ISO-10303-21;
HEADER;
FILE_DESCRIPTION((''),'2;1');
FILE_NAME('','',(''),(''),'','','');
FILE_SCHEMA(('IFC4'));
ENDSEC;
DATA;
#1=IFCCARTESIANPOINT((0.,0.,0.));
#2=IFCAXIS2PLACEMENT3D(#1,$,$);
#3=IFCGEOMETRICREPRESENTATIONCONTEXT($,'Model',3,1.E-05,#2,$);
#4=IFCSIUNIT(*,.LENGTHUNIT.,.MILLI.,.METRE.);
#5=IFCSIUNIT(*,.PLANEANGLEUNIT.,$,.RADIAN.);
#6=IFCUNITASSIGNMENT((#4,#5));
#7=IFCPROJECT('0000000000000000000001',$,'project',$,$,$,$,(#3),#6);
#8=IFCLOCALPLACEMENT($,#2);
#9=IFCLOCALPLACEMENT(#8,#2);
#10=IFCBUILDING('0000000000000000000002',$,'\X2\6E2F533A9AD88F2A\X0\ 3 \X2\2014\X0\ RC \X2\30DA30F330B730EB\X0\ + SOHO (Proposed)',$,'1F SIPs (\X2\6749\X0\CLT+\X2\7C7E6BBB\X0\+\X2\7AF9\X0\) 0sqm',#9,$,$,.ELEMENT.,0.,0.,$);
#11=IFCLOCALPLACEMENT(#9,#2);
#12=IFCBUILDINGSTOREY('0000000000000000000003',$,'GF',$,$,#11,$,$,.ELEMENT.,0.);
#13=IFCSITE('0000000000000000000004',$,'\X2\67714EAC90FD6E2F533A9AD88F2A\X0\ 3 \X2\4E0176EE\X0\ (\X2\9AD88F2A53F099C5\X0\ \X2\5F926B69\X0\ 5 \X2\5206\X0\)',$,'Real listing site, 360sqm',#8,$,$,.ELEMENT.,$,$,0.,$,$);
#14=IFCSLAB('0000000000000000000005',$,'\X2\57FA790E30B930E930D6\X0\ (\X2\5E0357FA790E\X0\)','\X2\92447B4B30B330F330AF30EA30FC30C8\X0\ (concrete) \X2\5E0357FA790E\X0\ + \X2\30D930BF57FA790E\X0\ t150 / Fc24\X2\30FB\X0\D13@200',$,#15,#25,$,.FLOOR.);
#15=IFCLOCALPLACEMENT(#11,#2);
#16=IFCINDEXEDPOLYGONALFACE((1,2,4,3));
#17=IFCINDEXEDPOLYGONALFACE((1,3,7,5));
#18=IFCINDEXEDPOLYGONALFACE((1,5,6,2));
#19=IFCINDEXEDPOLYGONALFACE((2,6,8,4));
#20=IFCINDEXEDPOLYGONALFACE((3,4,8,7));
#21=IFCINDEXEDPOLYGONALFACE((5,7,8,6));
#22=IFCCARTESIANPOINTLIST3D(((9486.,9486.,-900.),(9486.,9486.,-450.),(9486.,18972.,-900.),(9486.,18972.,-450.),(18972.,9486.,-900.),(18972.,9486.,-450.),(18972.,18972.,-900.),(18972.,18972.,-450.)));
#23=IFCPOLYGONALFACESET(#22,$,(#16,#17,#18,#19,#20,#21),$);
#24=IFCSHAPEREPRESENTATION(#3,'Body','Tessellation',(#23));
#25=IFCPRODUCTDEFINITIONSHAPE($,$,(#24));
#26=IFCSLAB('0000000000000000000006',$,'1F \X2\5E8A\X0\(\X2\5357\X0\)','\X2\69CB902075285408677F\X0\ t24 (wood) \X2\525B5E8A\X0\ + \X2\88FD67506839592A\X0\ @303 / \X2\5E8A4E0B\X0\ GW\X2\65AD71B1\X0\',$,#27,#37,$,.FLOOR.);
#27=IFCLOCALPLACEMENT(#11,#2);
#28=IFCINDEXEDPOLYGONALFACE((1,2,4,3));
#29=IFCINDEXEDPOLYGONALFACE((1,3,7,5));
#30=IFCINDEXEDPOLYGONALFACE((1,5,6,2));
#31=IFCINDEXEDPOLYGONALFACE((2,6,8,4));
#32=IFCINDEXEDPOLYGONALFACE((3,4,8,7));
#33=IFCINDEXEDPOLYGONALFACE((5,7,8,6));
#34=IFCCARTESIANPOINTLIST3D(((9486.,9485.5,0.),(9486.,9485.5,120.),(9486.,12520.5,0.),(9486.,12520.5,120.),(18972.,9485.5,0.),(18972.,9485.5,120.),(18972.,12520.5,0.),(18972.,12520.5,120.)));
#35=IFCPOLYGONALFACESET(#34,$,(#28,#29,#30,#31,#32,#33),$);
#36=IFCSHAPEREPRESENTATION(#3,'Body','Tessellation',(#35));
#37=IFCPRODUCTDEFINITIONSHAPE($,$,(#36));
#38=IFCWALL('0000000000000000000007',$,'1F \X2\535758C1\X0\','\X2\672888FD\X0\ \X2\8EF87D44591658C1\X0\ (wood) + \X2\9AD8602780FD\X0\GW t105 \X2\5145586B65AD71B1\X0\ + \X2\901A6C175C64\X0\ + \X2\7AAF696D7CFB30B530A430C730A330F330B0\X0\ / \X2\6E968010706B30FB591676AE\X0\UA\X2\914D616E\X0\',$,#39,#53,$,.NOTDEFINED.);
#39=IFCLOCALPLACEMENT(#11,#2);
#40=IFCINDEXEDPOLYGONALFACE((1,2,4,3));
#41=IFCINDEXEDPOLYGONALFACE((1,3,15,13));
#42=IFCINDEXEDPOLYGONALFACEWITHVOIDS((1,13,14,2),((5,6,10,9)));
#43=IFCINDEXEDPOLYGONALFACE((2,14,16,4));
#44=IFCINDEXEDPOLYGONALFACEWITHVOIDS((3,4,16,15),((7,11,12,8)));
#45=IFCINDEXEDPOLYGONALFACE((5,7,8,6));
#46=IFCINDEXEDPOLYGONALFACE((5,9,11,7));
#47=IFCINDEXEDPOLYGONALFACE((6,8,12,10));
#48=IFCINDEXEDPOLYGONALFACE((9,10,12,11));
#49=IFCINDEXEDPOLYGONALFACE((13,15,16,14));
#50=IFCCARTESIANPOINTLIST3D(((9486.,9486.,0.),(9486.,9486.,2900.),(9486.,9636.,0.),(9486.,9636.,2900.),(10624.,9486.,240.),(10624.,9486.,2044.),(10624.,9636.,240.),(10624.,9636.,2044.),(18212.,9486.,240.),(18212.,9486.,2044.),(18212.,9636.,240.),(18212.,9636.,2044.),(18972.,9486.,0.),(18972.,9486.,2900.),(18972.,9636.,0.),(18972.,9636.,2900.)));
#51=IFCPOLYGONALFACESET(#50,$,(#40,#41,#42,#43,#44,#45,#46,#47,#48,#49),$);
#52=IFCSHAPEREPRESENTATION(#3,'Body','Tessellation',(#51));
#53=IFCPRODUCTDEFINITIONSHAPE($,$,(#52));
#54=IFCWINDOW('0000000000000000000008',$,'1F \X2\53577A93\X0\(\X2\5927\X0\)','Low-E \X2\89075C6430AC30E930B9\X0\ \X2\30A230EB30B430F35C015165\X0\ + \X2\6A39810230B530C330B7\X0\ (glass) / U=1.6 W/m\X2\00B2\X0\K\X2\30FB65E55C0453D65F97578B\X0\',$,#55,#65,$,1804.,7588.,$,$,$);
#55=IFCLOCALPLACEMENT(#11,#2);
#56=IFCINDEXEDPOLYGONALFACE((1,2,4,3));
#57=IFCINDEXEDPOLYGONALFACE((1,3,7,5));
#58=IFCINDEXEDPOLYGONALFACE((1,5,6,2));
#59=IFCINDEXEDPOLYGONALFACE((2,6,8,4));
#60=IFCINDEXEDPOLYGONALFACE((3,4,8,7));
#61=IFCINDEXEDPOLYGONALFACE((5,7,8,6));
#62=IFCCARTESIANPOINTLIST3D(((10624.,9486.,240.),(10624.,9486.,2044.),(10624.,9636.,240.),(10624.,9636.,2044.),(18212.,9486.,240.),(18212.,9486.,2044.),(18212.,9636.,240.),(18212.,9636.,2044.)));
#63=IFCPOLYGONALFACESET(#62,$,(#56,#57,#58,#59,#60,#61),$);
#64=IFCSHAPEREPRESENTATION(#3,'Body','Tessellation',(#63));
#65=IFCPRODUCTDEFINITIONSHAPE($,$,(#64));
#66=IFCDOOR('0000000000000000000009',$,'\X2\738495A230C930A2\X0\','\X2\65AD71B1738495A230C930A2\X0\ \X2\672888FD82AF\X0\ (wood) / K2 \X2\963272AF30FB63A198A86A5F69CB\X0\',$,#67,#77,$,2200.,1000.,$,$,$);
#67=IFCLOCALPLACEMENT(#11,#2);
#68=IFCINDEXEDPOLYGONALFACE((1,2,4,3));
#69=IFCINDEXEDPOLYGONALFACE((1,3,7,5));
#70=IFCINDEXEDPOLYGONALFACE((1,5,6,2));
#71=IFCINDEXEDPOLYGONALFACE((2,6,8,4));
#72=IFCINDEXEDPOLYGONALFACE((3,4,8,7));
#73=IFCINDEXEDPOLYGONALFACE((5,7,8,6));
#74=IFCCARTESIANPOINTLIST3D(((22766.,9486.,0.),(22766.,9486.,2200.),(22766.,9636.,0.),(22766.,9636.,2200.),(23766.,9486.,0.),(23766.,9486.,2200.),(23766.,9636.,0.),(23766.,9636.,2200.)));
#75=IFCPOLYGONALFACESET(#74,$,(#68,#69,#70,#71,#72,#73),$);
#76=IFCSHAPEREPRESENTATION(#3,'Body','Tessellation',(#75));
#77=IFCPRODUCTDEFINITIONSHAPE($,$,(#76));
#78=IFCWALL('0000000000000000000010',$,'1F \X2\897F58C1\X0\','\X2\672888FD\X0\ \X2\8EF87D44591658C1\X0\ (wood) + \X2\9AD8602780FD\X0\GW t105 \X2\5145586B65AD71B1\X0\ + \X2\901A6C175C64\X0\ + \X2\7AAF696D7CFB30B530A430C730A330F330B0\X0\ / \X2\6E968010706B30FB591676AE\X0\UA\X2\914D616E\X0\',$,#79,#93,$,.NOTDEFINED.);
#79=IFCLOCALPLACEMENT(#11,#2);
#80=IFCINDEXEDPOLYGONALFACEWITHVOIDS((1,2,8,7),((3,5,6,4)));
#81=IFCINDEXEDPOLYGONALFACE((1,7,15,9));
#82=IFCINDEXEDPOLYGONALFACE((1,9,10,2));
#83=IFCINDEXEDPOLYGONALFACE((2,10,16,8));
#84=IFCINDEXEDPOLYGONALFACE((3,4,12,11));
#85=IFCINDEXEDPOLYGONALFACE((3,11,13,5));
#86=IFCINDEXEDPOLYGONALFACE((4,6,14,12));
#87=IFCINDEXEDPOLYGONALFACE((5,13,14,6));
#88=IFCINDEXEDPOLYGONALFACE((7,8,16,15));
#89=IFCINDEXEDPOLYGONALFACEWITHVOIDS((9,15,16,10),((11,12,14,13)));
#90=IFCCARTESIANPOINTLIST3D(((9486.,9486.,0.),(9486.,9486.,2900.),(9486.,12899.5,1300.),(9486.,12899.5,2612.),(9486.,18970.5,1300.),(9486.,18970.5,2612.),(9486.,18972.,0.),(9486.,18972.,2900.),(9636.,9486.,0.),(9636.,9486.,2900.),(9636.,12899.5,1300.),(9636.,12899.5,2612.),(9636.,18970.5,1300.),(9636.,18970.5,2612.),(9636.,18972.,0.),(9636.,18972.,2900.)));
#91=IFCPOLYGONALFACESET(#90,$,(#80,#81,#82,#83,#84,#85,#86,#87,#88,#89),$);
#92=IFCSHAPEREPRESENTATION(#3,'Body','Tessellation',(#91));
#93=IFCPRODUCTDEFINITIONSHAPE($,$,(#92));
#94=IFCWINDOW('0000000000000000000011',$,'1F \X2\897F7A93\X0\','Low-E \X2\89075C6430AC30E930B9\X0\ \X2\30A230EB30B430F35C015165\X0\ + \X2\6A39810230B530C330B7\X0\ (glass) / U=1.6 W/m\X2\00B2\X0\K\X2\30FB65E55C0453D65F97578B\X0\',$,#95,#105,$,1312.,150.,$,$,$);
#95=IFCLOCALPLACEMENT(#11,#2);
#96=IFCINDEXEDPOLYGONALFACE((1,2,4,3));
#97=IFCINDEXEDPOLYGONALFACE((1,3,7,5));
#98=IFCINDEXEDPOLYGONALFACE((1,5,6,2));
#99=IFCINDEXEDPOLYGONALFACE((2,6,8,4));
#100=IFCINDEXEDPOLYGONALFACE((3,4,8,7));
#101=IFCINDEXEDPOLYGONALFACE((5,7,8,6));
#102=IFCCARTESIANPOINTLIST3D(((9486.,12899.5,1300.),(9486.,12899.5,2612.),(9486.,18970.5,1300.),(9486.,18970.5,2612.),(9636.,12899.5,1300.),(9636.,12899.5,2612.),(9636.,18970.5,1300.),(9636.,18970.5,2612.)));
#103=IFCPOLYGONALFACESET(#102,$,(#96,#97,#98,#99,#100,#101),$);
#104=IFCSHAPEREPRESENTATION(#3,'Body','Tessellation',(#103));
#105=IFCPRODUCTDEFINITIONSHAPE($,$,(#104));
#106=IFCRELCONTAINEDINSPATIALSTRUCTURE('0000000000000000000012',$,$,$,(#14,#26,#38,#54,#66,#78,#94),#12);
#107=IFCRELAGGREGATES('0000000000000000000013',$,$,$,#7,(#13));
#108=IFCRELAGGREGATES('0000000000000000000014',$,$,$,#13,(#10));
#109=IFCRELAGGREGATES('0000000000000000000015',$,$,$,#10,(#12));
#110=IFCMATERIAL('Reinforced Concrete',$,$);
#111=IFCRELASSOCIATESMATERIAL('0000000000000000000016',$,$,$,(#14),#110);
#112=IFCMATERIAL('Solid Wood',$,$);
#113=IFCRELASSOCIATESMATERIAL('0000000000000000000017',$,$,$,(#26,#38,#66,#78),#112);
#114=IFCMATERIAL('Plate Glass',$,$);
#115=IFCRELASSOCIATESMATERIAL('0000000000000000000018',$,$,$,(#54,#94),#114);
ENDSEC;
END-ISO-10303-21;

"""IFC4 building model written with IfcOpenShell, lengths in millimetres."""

from ifc_helpers import new_model, si_unit, frame, frame_2d, origin, place, context, project, spatial, rectangle, extrude, material, element, fill, save


model = new_model("IFC4")

# Units and contexts
model_context = context("Model", 3, precision=1e-05, world=origin())
ifc_project = project(units=[si_unit("LENGTHUNIT", "METRE", prefix="MILLI"), si_unit("PLANEANGLEUNIT", "RADIAN")], contexts=[model_context])

# Site, building, storey
site_placement = place(None, origin())
site = spatial("IfcSite", under=ifc_project, at=site_placement, Name="東京都港区高輪 3 丁目 (高輪台駅 徒歩 5 分)", ObjectType="Real listing site, 360sqm", CompositionType="ELEMENT", RefElevation=0.0)
building_placement = place(site_placement, origin())
building = spatial("IfcBuilding", under=site, at=building_placement, Name="港区高輪 3 — RC ペンシル + SOHO (Proposed)", ObjectType="1F SIPs (杉CLT+籾殻+竹) 0sqm", CompositionType="ELEMENT", ElevationOfRefHeight=0.0, ElevationOfTerrain=0.0)
storey_placement = place(building_placement, origin())
storey = spatial("IfcBuildingStorey", under=building, at=storey_placement, Name="GF", CompositionType="ELEMENT", Elevation=0.0)

# Slabs
ifc_material_1 = material(Name="Reinforced Concrete")
slab_1_placement = place(storey_placement, frame((4743.0, 4743.0, -450.0)))
element("IfcSlab", 1, at=slab_1_placement, inside=storey, material=ifc_material_1, Name="基礎スラブ (布基礎)", Description="鉄筋コンクリート (concrete) 布基礎 + ベタ基礎 t150 / Fc24・D13@200", PredefinedType="FLOOR", context=model_context, shape_type="SweptSolid", body=[
    extrude(rectangle(XDim=9486.0, YDim=9486.0, at=frame_2d((4743.0, 4743.0))), frame((4743.0, 4743.0, -450.0)), (0.0, 0.0, 1.0), 450.0),
])
ifc_material_2 = material(Name="Solid Wood")
slab_2_placement = place(storey_placement, frame((4743.0, 4743.0, 0.0)))
element("IfcSlab", 2, at=slab_2_placement, inside=storey, material=ifc_material_2, Name="1F 床(南)", Description="構造用合板 t24 (wood) 剛床 + 製材根太 @303 / 床下 GW断熱", PredefinedType="FLOOR", context=model_context, shape_type="SweptSolid", body=[
    extrude(rectangle(XDim=9486.0, YDim=3035.0, at=frame_2d((4743.0, 1517.0))), frame((4743.0, 4743.0, 0.0)), (0.0, 0.0, 1.0), 120.0),
])

# Wall, openings, window, door
wall_1_placement = place(storey_placement, frame((4743.0, 4743.0, 0.0)))
wall_1 = element("IfcWall", 3, at=wall_1_placement, inside=storey, material=ifc_material_2, Name="1F 南壁", Description="木製 軸組外壁 (wood) + 高性能GW t105 充填断熱 + 通気層 + 窯業系サイディング / 準耐火・外皮UA配慮", PredefinedType="NOTDEFINED", context=model_context, shape_type="SweptSolid", body=[
    extrude(rectangle(XDim=9486.0, YDim=150.0, at=frame_2d((4743.0, 75.0))), frame((4743.0, 4743.0, 0.0)), (0.0, 0.0, 1.0), 2900.0),
])
opening_1_placement = place(storey_placement, frame((5312.0, 4743.0, 120.0)))
opening_1 = element("IfcOpeningElement", 4, at=opening_1_placement, cuts=wall_1, PredefinedType="NOTDEFINED", context=model_context, shape_type="SweptSolid", body=[
    extrude(rectangle(XDim=7588.0, YDim=150.0, at=frame_2d((3794.0, 75.0))), frame((5312.0, 4743.0, 120.0)), (0.0, 0.0, 1.0), 1804.0),
])
opening_2_placement = place(storey_placement, frame((11383.0, 4743.0, 0.0)))
opening_2 = element("IfcOpeningElement", 5, at=opening_2_placement, cuts=wall_1, PredefinedType="NOTDEFINED", context=model_context, shape_type="SweptSolid", body=[
    extrude(rectangle(XDim=1000.0, YDim=150.0, at=frame_2d((500.0, 75.0))), frame((11383.0, 4743.0, 0.0)), (0.0, 0.0, 1.0), 2200.0),
])
ifc_material_3 = material(Name="Plate Glass")
window_1_placement = place(storey_placement, frame((5312.0, 4743.0, 120.0)))
window_1 = element("IfcWindow", 6, at=window_1_placement, inside=storey, material=ifc_material_3, Name="1F 南窓(大)", Description="Low-E 複層ガラス アルゴン封入 + 樹脂サッシ (glass) / U=1.6 W/m²K・日射取得型", OverallHeight=1804.0, OverallWidth=7588.0, context=model_context, shape_type="SweptSolid", body=[
    extrude(rectangle(XDim=7588.0, YDim=150.0, at=frame_2d((3794.0, 75.0))), frame((5312.0, 4743.0, 120.0)), (0.0, 0.0, 1.0), 1804.0),
])
fill(opening_1, window_1)
door_1_placement = place(storey_placement, frame((11383.0, 4743.0, 0.0)))
door_1 = element("IfcDoor", 7, at=door_1_placement, inside=storey, material=ifc_material_2, Name="玄関ドア", Description="断熱玄関ドア 木製芯 (wood) / K2 防犯・採風機構", OverallHeight=2200.0, OverallWidth=1000.0, context=model_context, shape_type="SweptSolid", body=[
    extrude(rectangle(XDim=1000.0, YDim=150.0, at=frame_2d((500.0, 75.0))), frame((11383.0, 4743.0, 0.0)), (0.0, 0.0, 1.0), 2200.0),
])
fill(opening_2, door_1)

# Wall, opening, window
wall_2_placement = place(storey_placement, frame((4743.0, 4743.0, 0.0)))
wall_2 = element("IfcWall", 8, at=wall_2_placement, inside=storey, material=ifc_material_2, Name="1F 西壁", Description="木製 軸組外壁 (wood) + 高性能GW t105 充填断熱 + 通気層 + 窯業系サイディング / 準耐火・外皮UA配慮", PredefinedType="NOTDEFINED", context=model_context, shape_type="SweptSolid", body=[
    extrude(rectangle(XDim=150.0, YDim=9486.0, at=frame_2d((75.0, 4743.0))), frame((4743.0, 4743.0, 0.0)), (0.0, 0.0, 1.0), 2900.0),
])
opening_3_placement = place(storey_placement, frame((4743.0, 6450.0, 650.0)))
opening_3 = element("IfcOpeningElement", 9, at=opening_3_placement, cuts=wall_2, PredefinedType="NOTDEFINED", context=model_context, shape_type="SweptSolid", body=[
    extrude(rectangle(XDim=150.0, YDim=6071.0, at=frame_2d((75.0, 3035.0))), frame((4743.0, 6450.0, 650.0)), (0.0, 0.0, 1.0), 1312.0),
])
window_2_placement = place(storey_placement, frame((4743.0, 6450.0, 650.0)))
window_2 = element("IfcWindow", 10, at=window_2_placement, inside=storey, material=ifc_material_3, Name="1F 西窓", Description="Low-E 複層ガラス アルゴン封入 + 樹脂サッシ (glass) / U=1.6 W/m²K・日射取得型", OverallHeight=1312.0, OverallWidth=150.0, context=model_context, shape_type="SweptSolid", body=[
    extrude(rectangle(XDim=150.0, YDim=6071.0, at=frame_2d((75.0, 3035.0))), frame((4743.0, 6450.0, 650.0)), (0.0, 0.0, 1.0), 1312.0),
])
fill(opening_3, window_2)

save(model, "model.ifc")
